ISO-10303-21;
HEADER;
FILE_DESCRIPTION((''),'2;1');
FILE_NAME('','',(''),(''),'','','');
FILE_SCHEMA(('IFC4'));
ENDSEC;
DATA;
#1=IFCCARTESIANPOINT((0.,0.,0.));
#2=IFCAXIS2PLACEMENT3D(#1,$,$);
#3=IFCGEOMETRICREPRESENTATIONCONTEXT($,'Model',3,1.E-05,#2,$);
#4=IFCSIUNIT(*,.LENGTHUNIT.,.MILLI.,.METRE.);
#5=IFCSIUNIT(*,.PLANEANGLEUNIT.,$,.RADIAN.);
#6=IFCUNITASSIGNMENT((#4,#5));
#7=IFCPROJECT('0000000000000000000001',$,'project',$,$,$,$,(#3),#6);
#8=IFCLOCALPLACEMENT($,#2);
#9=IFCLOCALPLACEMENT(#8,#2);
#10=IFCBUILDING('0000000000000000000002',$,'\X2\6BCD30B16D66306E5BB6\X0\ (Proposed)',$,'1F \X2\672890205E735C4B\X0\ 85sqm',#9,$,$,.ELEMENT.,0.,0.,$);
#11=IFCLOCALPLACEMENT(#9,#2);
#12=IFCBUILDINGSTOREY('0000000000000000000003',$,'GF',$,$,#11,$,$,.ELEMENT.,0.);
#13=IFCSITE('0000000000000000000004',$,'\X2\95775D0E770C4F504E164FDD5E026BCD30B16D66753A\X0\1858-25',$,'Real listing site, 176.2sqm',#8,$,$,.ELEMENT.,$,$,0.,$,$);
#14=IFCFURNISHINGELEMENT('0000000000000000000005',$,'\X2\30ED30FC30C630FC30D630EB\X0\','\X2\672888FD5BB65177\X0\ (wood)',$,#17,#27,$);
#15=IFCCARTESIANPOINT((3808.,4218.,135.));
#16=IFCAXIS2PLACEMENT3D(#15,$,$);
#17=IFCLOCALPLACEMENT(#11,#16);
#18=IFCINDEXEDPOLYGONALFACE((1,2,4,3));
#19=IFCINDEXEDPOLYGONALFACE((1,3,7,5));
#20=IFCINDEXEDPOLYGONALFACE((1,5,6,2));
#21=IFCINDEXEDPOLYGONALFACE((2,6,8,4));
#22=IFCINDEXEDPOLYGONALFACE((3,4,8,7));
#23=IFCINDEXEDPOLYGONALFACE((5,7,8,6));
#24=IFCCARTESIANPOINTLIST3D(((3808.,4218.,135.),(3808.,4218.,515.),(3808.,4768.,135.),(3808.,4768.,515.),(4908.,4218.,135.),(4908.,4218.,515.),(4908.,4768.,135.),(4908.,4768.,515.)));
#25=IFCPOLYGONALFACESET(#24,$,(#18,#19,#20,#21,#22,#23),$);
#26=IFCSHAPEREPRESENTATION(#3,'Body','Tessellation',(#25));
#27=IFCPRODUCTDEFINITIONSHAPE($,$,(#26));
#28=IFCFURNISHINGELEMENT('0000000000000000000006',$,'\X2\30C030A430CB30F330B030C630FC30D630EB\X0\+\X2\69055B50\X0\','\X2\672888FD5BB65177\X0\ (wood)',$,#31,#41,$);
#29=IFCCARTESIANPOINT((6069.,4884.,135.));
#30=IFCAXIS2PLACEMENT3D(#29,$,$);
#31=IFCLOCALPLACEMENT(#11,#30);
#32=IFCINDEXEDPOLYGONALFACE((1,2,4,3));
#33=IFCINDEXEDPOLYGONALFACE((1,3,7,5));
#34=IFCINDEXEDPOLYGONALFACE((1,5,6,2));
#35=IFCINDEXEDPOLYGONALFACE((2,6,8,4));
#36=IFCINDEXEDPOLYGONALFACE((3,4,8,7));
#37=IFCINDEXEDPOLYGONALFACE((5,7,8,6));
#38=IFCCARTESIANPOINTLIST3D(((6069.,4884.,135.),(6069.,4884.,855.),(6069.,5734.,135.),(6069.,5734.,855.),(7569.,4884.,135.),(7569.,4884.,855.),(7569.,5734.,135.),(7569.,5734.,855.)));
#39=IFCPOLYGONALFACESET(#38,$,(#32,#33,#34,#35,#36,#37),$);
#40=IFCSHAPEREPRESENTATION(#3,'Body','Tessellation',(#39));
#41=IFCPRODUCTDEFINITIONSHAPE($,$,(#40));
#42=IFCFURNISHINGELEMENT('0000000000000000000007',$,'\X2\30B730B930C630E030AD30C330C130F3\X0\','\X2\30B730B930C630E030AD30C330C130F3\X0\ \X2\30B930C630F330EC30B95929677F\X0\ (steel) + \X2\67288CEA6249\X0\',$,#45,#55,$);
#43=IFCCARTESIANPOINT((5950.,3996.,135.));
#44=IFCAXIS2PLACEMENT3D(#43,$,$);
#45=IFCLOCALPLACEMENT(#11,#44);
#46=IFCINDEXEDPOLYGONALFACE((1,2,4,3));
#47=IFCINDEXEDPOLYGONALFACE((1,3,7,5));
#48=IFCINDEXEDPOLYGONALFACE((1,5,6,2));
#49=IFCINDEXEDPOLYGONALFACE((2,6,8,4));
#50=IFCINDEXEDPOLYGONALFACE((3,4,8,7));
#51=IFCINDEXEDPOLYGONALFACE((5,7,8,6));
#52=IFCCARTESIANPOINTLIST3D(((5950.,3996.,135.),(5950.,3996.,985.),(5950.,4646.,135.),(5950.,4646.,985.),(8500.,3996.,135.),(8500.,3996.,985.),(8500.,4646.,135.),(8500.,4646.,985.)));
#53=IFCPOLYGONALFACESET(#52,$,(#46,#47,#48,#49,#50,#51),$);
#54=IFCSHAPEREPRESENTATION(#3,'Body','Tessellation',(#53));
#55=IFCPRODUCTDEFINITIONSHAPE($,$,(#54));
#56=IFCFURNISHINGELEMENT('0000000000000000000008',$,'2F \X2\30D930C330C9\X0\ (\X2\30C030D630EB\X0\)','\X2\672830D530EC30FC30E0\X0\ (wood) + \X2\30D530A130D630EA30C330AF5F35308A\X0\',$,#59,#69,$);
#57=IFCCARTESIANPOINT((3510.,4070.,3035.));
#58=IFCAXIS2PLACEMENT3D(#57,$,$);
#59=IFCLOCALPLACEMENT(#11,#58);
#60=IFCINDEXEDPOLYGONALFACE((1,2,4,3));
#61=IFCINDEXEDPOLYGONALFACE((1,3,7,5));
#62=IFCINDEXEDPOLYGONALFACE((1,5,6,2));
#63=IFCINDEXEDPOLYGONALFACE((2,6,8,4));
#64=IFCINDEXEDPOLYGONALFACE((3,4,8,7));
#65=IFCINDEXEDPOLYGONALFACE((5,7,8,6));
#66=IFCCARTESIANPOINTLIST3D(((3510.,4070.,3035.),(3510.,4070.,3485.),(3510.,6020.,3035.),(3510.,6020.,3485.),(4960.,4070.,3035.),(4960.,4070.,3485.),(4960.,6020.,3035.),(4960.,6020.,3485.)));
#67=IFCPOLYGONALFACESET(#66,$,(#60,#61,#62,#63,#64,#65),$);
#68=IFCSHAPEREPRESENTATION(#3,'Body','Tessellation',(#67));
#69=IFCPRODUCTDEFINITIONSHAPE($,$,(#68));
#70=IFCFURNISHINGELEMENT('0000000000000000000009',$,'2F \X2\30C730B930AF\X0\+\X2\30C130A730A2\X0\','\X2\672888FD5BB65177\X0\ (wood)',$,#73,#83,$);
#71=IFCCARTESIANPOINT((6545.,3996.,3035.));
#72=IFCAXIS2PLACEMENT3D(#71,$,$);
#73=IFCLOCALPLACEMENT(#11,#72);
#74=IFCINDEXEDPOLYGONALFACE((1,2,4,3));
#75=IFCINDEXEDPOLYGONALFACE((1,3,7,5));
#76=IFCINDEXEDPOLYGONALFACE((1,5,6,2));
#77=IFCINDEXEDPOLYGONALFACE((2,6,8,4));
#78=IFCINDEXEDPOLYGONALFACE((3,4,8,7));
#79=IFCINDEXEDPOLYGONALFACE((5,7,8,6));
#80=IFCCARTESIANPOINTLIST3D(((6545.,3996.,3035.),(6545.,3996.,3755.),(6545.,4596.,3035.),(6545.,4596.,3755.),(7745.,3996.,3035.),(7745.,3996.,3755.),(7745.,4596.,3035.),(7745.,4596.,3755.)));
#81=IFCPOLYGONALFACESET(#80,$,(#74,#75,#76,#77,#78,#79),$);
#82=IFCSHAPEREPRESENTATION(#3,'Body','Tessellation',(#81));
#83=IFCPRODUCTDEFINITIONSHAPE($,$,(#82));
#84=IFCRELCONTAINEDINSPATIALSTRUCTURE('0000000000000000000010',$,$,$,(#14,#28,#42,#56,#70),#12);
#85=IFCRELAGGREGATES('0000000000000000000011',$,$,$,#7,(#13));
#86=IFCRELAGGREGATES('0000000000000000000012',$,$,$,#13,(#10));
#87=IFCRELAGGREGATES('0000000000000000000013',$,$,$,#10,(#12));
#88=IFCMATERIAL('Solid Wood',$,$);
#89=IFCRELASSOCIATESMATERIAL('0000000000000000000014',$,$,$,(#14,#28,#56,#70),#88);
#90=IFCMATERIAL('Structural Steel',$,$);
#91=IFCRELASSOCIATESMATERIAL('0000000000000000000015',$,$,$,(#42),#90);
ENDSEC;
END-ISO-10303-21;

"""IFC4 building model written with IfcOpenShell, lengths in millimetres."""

from ifc_helpers import new_model, si_unit, frame, frame_2d, origin, place, context, project, spatial, rectangle, extrude, material, element, save


model = new_model("IFC4")

# Units and contexts
model_context = context("Model", 3, precision=1e-05, world=origin())
ifc_project = project(units=[si_unit("LENGTHUNIT", "METRE", prefix="MILLI"), si_unit("PLANEANGLEUNIT", "RADIAN")], contexts=[model_context])

# Site, building, storey
site_placement = place(None, origin())
site = spatial("IfcSite", under=ifc_project, at=site_placement, Name="長崎県佐世保市母ケ浦町1858-25", ObjectType="Real listing site, 176.2sqm", CompositionType="ELEMENT", RefElevation=0.0)
building_placement = place(site_placement, origin())
building = spatial("IfcBuilding", under=site, at=building_placement, Name="母ケ浦の家 (Proposed)", ObjectType="1F 木造平屋 85sqm", CompositionType="ELEMENT", ElevationOfRefHeight=0.0, ElevationOfTerrain=0.0)
storey_placement = place(building_placement, origin())
storey = spatial("IfcBuildingStorey", under=building, at=storey_placement, Name="GF", CompositionType="ELEMENT", Elevation=0.0)

# Shared definitions
ifc_material_1 = material(Name="Solid Wood")

# Shared definitions
ifc_material_2 = material(Name="Structural Steel")

# Furnishing elements
furnishing_1_placement = place(storey_placement, frame((3808.0, 4218.0, 135.0)))
element("IfcFurnishingElement", 1, at=furnishing_1_placement, inside=storey, material=ifc_material_1, Name="ローテーブル", Description="木製家具 (wood)", context=model_context, shape_type="SweptSolid", body=[
    extrude(rectangle(XDim=1100.0, YDim=550.0, at=frame_2d((550.0, 275.0))), frame((3808.0, 4218.0, 135.0)), (0.0, 0.0, 1.0), 380.0),
])
furnishing_2_placement = place(storey_placement, frame((6069.0, 4884.0, 135.0)))
element("IfcFurnishingElement", 2, at=furnishing_2_placement, inside=storey, material=ifc_material_1, Name="ダイニングテーブル+椅子", Description="木製家具 (wood)", context=model_context, shape_type="SweptSolid", body=[
    extrude(rectangle(XDim=1500.0, YDim=850.0, at=frame_2d((750.0, 425.0))), frame((6069.0, 4884.0, 135.0)), (0.0, 0.0, 1.0), 720.0),
])
furnishing_3_placement = place(storey_placement, frame((5950.0, 3996.0, 135.0)))
element("IfcFurnishingElement", 3, at=furnishing_3_placement, inside=storey, material=ifc_material_2, Name="システムキッチン", Description="システムキッチン ステンレス天板 (steel) + 木質扉", context=model_context, shape_type="SweptSolid", body=[
    extrude(rectangle(XDim=2550.0, YDim=650.0, at=frame_2d((1275.0, 325.0))), frame((5950.0, 3996.0, 135.0)), (0.0, 0.0, 1.0), 850.0),
])
furnishing_4_placement = place(storey_placement, frame((3510.0, 4070.0, 3035.0)))
element("IfcFurnishingElement", 4, at=furnishing_4_placement, inside=storey, material=ifc_material_1, Name="2F ベッド (ダブル)", Description="木フレーム (wood) + ファブリック張り", context=model_context, shape_type="SweptSolid", body=[
    extrude(rectangle(XDim=1450.0, YDim=1950.0, at=frame_2d((725.0, 975.0))), frame((3510.0, 4070.0, 3035.0)), (0.0, 0.0, 1.0), 450.0),
])
furnishing_5_placement = place(storey_placement, frame((6545.0, 3996.0, 3035.0)))
element("IfcFurnishingElement", 5, at=furnishing_5_placement, inside=storey, material=ifc_material_1, Name="2F デスク+チェア", Description="木製家具 (wood)", context=model_context, shape_type="SweptSolid", body=[
    extrude(rectangle(XDim=1200.0, YDim=600.0, at=frame_2d((600.0, 300.0))), frame((6545.0, 3996.0, 3035.0)), (0.0, 0.0, 1.0), 720.0),
])

save(model, "model.ifc")
